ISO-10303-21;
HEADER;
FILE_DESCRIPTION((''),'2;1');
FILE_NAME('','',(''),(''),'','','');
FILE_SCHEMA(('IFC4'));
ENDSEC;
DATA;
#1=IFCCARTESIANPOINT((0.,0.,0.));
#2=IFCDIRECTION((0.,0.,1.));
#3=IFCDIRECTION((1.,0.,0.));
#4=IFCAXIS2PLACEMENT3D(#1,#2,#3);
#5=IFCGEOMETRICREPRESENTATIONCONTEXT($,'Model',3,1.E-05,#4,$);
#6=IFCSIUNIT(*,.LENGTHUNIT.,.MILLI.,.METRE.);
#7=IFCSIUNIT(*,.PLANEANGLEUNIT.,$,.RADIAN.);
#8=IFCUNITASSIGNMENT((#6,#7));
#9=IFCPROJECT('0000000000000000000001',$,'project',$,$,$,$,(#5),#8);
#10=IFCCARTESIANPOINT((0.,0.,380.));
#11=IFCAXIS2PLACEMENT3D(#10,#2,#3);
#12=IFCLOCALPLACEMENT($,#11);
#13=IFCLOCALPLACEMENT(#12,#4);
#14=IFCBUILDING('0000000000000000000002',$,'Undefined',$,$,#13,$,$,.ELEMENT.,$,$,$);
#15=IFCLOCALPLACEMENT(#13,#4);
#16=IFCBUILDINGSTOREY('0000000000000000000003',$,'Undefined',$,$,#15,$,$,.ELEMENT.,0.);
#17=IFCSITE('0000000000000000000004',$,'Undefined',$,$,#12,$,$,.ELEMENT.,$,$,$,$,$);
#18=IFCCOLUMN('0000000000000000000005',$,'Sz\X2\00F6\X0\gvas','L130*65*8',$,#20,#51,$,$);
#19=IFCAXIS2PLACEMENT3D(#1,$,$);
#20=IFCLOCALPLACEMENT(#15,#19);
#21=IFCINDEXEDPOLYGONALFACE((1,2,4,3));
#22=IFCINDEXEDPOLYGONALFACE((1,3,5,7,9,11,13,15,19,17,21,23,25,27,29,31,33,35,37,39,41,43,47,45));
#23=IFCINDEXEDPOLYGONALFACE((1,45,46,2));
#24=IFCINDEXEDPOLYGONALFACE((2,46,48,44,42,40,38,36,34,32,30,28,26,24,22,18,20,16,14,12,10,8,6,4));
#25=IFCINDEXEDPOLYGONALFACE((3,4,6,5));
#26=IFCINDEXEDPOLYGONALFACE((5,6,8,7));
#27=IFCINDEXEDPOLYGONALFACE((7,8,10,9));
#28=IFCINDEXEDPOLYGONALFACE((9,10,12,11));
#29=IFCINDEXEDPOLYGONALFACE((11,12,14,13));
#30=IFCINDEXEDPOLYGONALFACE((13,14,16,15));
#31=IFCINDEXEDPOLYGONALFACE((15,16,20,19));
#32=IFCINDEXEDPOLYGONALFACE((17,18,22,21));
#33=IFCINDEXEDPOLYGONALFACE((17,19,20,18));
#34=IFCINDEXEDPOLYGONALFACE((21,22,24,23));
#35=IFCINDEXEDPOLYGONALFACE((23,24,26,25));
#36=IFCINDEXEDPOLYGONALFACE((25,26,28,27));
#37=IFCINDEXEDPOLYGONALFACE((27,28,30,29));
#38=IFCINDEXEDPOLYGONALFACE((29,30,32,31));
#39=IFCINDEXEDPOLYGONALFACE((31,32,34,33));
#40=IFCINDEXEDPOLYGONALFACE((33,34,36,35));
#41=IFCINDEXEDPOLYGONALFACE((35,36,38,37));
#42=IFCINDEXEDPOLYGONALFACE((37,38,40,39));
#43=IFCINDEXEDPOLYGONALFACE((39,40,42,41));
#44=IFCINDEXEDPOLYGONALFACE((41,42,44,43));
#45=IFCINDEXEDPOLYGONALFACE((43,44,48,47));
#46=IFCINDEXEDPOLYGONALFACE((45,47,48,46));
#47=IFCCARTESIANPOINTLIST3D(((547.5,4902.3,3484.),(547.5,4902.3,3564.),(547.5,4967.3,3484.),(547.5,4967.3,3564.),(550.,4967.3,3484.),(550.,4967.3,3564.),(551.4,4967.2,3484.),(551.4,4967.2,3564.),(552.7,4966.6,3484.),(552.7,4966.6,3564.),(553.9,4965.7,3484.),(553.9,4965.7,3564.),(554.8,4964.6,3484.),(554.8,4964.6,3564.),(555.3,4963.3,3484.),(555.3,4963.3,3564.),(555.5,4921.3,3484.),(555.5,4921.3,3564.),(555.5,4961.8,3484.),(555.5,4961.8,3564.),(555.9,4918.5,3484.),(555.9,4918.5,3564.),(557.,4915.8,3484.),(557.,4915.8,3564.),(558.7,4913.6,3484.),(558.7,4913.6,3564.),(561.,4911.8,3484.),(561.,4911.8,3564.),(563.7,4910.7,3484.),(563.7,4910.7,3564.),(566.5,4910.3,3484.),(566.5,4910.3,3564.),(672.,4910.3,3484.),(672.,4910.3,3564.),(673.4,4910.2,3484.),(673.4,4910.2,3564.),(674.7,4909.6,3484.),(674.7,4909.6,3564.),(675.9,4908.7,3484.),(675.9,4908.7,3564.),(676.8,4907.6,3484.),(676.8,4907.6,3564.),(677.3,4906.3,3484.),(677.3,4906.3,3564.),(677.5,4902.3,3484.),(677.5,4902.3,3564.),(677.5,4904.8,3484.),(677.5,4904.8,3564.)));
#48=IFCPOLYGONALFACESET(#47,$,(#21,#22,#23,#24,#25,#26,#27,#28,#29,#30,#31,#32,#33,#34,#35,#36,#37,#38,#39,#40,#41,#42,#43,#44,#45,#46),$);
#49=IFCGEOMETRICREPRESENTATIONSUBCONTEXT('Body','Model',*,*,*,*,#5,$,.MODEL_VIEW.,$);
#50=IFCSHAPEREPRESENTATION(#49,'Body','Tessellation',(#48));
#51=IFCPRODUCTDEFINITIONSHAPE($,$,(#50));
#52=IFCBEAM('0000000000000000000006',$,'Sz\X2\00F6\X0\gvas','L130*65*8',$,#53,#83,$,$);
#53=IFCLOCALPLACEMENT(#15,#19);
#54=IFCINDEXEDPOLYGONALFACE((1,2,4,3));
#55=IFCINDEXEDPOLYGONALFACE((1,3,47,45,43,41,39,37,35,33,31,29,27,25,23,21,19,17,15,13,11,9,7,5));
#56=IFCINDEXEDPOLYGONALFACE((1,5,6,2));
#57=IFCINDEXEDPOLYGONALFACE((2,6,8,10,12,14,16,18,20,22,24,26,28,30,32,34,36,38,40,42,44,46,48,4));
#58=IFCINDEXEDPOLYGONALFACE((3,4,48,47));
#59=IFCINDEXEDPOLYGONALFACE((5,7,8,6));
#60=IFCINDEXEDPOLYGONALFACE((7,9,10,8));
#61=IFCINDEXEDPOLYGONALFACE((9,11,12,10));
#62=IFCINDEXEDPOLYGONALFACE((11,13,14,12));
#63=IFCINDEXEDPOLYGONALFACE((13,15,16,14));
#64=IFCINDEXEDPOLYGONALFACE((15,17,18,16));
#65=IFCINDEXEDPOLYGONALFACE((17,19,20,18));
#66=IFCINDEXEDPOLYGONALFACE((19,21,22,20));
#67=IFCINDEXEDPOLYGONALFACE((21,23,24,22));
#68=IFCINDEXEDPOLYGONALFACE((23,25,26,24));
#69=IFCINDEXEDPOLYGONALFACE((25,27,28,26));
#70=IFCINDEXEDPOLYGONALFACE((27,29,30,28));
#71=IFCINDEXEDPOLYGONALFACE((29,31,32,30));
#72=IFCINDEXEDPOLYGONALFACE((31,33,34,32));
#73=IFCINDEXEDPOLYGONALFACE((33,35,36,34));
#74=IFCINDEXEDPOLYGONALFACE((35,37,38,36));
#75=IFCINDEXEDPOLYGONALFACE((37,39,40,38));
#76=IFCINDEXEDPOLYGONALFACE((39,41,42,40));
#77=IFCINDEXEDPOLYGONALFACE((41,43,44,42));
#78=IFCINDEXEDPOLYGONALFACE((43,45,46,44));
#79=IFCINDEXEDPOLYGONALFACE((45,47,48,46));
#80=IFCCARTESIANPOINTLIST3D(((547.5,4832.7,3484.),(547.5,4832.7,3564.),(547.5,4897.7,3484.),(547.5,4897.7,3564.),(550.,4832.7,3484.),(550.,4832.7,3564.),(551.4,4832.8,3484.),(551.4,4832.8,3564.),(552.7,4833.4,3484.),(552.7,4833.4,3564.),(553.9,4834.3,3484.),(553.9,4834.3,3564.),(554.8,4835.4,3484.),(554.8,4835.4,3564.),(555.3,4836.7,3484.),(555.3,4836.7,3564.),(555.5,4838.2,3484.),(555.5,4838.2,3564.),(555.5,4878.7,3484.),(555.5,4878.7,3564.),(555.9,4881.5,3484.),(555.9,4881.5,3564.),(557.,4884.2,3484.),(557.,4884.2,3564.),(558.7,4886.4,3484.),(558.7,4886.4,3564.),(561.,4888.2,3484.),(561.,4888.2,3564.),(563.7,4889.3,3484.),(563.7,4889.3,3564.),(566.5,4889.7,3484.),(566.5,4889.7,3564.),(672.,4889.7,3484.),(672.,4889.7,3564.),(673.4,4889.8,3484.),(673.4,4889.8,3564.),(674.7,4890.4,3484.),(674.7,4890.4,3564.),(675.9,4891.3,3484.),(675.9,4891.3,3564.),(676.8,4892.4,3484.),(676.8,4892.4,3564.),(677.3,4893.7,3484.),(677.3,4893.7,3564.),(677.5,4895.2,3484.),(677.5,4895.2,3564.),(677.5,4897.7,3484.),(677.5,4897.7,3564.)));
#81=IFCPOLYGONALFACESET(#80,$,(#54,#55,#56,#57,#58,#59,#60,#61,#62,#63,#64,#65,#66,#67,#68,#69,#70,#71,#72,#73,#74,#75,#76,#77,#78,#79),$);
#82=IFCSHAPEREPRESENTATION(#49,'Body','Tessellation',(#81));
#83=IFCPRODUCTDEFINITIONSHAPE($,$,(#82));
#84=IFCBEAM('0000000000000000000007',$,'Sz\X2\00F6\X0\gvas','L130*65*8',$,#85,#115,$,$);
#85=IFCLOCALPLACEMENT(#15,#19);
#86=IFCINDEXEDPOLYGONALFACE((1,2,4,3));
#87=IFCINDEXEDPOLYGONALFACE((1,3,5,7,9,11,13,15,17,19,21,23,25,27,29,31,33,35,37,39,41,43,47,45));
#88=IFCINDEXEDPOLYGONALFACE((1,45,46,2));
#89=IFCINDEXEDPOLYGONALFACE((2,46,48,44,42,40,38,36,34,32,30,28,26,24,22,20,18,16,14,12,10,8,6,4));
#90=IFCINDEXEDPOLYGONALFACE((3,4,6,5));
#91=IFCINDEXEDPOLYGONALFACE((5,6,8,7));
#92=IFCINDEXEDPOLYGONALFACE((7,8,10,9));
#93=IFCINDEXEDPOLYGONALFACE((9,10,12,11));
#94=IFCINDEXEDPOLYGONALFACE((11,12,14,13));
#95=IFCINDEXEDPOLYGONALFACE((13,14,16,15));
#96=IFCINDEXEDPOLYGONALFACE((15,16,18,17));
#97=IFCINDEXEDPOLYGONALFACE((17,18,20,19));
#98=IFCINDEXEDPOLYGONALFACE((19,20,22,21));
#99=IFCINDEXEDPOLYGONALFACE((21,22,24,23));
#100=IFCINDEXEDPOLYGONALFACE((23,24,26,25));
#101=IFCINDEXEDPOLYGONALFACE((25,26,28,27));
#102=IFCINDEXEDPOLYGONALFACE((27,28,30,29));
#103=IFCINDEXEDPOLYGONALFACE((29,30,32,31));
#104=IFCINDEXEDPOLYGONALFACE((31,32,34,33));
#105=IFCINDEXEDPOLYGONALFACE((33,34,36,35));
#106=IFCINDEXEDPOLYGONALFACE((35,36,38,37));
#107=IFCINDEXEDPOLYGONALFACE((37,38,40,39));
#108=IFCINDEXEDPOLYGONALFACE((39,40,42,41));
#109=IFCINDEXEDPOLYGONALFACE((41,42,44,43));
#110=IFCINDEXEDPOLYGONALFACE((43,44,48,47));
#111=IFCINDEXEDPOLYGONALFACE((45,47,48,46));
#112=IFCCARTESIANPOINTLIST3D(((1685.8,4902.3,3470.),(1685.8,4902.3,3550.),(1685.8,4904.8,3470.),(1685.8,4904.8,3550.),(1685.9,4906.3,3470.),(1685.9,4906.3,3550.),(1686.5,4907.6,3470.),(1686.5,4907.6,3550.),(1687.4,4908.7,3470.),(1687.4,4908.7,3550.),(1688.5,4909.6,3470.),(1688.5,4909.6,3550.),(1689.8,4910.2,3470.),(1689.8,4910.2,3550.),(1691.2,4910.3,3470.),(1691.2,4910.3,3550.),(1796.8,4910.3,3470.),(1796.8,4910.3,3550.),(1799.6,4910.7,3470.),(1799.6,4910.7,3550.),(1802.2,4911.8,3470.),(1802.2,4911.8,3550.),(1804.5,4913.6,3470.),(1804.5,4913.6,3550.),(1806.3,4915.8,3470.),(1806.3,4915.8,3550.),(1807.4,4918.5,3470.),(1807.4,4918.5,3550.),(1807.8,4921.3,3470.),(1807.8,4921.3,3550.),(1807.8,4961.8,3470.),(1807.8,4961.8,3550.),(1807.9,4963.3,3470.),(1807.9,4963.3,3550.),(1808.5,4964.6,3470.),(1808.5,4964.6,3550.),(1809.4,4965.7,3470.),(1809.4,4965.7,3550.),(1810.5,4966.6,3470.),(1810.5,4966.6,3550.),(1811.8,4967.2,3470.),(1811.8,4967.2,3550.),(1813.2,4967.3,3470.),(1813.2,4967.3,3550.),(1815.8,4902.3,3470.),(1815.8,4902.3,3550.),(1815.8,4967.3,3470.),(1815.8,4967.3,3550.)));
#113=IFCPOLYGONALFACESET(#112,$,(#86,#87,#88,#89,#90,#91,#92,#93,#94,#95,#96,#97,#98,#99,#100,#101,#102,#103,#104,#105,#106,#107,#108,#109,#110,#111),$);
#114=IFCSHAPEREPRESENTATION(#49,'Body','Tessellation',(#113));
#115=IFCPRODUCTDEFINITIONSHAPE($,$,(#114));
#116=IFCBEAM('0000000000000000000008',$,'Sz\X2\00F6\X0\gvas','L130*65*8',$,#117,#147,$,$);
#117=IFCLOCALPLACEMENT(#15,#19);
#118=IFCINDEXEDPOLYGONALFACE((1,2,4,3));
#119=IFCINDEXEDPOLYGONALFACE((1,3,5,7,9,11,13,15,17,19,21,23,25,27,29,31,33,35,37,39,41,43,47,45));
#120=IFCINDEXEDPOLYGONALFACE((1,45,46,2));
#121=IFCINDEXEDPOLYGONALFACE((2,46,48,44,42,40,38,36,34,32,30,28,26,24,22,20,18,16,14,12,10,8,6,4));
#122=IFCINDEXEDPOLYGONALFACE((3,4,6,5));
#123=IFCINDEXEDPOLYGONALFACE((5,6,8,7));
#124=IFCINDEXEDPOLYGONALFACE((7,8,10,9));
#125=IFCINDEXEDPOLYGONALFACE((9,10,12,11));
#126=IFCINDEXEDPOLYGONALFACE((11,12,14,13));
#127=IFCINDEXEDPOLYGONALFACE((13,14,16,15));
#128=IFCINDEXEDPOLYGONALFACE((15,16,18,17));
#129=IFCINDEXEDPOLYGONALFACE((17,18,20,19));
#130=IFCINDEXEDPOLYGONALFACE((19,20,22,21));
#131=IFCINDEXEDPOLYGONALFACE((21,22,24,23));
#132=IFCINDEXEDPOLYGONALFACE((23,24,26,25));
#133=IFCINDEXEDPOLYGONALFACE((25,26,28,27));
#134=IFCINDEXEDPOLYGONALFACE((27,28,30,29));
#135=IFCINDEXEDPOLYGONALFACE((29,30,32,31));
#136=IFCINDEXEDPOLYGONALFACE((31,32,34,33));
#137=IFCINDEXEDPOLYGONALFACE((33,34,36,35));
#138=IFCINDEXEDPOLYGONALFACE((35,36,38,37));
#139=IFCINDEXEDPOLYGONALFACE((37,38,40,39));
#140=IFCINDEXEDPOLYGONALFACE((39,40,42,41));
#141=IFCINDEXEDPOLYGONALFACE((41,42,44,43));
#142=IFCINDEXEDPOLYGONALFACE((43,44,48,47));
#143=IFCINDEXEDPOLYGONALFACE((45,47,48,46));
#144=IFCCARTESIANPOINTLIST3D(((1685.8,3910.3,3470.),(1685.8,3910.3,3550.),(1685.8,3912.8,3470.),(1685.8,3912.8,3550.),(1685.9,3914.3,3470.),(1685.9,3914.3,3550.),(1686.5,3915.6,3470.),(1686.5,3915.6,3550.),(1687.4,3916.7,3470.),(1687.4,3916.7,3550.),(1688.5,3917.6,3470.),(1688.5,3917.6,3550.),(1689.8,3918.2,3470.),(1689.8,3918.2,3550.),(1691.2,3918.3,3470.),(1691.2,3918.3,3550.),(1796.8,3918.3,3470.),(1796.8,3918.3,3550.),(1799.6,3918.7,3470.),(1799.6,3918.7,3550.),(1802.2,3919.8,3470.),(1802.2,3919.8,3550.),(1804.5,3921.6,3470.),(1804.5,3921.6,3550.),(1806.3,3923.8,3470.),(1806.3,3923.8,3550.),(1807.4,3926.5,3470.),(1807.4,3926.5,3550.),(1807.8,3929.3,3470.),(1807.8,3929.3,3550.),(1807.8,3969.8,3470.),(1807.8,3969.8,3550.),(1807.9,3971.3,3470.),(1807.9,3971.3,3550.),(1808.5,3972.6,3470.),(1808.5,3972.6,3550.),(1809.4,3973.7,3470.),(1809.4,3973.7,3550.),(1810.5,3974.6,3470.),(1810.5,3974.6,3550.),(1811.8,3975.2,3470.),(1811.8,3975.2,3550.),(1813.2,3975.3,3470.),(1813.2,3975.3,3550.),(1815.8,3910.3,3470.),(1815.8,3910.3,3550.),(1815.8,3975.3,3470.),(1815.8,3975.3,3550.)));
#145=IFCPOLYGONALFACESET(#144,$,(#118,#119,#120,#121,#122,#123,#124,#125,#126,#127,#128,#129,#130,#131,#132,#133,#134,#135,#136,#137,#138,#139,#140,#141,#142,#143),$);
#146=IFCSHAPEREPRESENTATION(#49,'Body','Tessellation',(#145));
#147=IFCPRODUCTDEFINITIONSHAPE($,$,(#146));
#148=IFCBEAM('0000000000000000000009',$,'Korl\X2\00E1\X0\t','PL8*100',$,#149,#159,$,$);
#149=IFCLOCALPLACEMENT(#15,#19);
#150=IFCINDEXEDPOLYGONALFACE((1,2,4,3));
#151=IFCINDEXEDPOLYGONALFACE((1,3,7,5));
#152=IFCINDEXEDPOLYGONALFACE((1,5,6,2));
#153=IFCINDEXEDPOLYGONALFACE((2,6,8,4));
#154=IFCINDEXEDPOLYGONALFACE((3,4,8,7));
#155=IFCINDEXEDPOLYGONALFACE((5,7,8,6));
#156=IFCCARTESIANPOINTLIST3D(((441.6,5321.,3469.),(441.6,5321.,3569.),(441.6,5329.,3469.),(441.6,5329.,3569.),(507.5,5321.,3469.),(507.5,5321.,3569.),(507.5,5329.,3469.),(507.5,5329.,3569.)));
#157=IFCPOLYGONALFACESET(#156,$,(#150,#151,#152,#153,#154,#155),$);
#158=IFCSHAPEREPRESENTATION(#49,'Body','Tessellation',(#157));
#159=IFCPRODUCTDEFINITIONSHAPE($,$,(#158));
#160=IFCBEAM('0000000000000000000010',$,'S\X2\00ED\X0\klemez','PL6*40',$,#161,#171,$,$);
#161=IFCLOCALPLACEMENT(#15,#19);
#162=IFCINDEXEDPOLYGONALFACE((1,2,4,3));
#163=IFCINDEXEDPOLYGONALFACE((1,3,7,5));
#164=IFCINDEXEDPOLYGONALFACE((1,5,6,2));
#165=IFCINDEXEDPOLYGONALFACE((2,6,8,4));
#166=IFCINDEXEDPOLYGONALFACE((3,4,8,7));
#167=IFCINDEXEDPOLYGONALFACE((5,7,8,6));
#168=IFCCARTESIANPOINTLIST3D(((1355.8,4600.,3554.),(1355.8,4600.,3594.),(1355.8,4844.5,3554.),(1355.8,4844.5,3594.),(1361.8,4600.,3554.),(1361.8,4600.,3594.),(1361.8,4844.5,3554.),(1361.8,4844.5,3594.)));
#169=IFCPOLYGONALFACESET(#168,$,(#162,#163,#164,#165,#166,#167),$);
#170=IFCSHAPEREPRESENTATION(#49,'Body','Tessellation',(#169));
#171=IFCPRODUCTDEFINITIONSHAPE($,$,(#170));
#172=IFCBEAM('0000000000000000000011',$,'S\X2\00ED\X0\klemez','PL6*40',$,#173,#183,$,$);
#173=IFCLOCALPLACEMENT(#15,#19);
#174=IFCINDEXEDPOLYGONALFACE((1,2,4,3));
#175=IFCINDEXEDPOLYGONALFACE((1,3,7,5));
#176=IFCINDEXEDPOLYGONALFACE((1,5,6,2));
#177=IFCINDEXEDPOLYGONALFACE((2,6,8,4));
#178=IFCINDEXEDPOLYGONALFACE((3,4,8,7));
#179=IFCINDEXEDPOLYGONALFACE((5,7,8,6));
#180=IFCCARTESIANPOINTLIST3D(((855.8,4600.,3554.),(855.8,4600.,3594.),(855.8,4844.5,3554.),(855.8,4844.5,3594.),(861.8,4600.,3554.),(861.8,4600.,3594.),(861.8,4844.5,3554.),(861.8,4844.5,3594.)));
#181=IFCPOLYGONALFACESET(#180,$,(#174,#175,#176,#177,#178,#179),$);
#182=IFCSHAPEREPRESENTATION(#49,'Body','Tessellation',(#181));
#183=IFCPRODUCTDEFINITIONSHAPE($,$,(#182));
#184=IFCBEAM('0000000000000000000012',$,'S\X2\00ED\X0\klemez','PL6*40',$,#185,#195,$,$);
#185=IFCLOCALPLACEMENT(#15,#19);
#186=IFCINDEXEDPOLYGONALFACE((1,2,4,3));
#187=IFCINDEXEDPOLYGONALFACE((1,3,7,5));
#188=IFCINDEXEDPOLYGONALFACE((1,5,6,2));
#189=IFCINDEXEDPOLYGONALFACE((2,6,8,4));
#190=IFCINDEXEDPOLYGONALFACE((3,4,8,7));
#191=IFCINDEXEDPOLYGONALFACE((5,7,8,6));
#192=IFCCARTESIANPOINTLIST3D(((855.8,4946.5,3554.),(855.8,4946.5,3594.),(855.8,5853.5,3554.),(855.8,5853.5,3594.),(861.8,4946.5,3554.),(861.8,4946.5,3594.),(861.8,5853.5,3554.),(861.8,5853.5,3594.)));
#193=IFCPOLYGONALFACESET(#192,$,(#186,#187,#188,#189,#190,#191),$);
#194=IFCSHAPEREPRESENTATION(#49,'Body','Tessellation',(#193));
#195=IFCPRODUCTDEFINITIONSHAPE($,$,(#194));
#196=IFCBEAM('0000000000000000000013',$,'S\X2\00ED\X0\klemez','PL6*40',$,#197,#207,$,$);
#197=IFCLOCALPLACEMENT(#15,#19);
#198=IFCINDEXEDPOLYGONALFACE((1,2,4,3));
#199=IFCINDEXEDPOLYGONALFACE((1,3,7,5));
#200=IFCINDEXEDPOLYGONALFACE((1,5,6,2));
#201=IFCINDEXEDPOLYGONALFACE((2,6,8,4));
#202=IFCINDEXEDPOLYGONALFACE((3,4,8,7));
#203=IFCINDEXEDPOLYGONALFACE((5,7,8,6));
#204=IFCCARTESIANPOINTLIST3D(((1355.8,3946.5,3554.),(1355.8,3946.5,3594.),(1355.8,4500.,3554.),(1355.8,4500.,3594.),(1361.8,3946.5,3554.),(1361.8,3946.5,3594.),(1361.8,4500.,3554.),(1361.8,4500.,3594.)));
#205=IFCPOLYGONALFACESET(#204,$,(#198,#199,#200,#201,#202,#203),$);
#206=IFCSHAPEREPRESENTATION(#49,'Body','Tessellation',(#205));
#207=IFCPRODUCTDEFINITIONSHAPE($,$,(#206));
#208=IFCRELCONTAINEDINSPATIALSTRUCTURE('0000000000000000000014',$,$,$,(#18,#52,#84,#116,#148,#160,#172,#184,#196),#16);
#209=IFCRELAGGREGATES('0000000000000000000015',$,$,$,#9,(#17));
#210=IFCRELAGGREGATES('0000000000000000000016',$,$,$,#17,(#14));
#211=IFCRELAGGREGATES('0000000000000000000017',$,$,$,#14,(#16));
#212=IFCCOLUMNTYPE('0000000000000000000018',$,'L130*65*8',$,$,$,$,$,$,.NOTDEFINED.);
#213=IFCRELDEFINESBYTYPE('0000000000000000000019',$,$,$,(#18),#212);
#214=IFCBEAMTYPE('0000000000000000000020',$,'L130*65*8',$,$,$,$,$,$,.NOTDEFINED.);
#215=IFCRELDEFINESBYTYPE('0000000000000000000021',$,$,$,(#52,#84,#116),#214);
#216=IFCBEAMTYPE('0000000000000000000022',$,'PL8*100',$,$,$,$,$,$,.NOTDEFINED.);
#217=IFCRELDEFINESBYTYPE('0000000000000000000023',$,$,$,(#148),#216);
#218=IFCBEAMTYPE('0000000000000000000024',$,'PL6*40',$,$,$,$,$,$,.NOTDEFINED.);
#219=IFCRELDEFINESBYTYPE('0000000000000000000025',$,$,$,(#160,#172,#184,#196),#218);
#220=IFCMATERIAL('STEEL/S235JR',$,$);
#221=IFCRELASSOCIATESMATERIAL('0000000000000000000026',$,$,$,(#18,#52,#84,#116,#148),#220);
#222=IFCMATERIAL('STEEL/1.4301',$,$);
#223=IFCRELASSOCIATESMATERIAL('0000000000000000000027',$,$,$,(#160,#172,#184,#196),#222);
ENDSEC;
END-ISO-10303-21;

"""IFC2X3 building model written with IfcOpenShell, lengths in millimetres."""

from ifc_helpers import new_model, si_unit, frame, origin_with_axes, origin_2d_with_axis, place, context, subcontext, project, spatial, rectangle, l_section, extrude, material, type_object, element, save


model = new_model("IFC2X3")

# Units and contexts
model_context = context("Model", 3, precision=1e-05, world=origin_with_axes())
body_context = subcontext(model_context, "Body", "Model", "MODEL_VIEW")
ifc_project = project(units=[si_unit("LENGTHUNIT", "METRE", prefix="MILLI"), si_unit("PLANEANGLEUNIT", "RADIAN")], contexts=[model_context])

# Site, building, storey
site_placement = place(None, frame((0.0, 0.0, 380.0), z_axis=(0.0, 0.0, 1.0), x_axis=(1.0, 0.0, 0.0)))
site = spatial("IfcSite", under=ifc_project, at=site_placement, Name="Undefined", CompositionType="ELEMENT")
building_placement = place(site_placement, origin_with_axes())
building = spatial("IfcBuilding", under=site, at=building_placement, Name="Undefined", CompositionType="ELEMENT")
storey_placement = place(building_placement, origin_with_axes())
storey = spatial("IfcBuildingStorey", under=building, at=storey_placement, Name="Undefined", CompositionType="ELEMENT", Elevation=0.0)

# Column
ifc_material_1 = material(Name="STEEL/S235JR")
column_type_1 = type_object("IfcColumnType", Name="L130*65*8", PredefinedType="NOTDEFINED")
column_1_placement = place(storey_placement, frame((612.5, 4934.8, 3484.0), z_axis=(0.0, 0.0, 1.0), x_axis=(1.0, 0.0, 0.0)))
element("IfcColumn", 1, at=column_1_placement, inside=storey, type_object=column_type_1, material=ifc_material_1, Name="Szögvas", Description="L130*65*8", context=body_context, shape_type="SweptSolid", body=[
    extrude(l_section(Depth=130.0, Width=65.0, Thickness=8.0, FilletRadius=11.0, EdgeRadius=5.5, at=origin_2d_with_axis()), frame((0.0, 0.0, 80.0), z_axis=(0.0, 0.0, -1.0), x_axis=(0.0, 1.0, 0.0)), (0.0, 0.0, 1.0), 80.0),
])

# Beams
beam_type_1 = type_object("IfcBeamType", Name="L130*65*8", PredefinedType="NOTDEFINED")
for number, where, z_axis, x_axis, name in (
    (2, (612.5, 4865.2, 3564.0), (1.0, 0.0, 0.0), (0.0, 0.0, -1.0), "Szögvas"),
    (3, (1750.8, 4934.8, 3550.0), (-1.0, 0.0, 0.0), (0.0, 0.0, -1.0), "Szögvas"),
    (4, (1750.8, 3942.8, 3550.0), (-1.0, 0.0, 0.0), (0.0, 0.0, -1.0), "Szögvas"),
):
    element("IfcBeam", number, at=place(storey_placement, frame(where, z_axis=z_axis, x_axis=x_axis)), inside=storey, type_object=beam_type_1, material=ifc_material_1, Name=name, Description="L130*65*8", context=body_context, shape_type="SweptSolid", body=[
        extrude(l_section(Depth=130.0, Width=65.0, Thickness=8.0, FilletRadius=11.0, EdgeRadius=5.5, at=origin_2d_with_axis()), frame((80.0, 0.0, 0.0), z_axis=(-1.0, 0.0, 0.0), x_axis=(0.0, -1.0, 0.0)), (0.0, 0.0, 1.0), 80.0),
    ])
beam_type_2 = type_object("IfcBeamType", Name="PL8*100", PredefinedType="NOTDEFINED")
beam_1_placement = place(storey_placement, frame((507.5, 5325.0, 3519.0), z_axis=(0.0, 0.0, 1.0), x_axis=(-1.0, 0.0, 0.0)))
element("IfcBeam", 5, at=beam_1_placement, inside=storey, type_object=beam_type_2, material=ifc_material_1, Name="Korlát", Description="PL8*100", context=body_context, shape_type="SweptSolid", body=[
    extrude(rectangle(XDim=8.0, YDim=100.0, at=origin_2d_with_axis()), frame((65.9, 0.0, 0.0), z_axis=(-1.0, 0.0, 0.0), x_axis=(0.0, -1.0, 0.0)), (0.0, 0.0, 1.0), 65.8),
])
ifc_material_2 = material(Name="STEEL/1.4301")
beam_type_3 = type_object("IfcBeamType", Name="PL6*40", PredefinedType="NOTDEFINED")
for number, where, z_axis, x_axis, name in (
    (6, (1358.8, 4844.5, 3574.0), (0.0, 0.0, 1.0), (0.0, -1.0, 0.0), "Síklemez"),
    (7, (858.8, 4844.5, 3574.0), (0.0, 0.0, 1.0), (0.0, -1.0, 0.0), "Síklemez"),
):
    element("IfcBeam", number, at=place(storey_placement, frame(where, z_axis=z_axis, x_axis=x_axis)), inside=storey, type_object=beam_type_3, material=ifc_material_2, Name=name, Description="PL6*40", context=body_context, shape_type="SweptSolid", body=[
        extrude(rectangle(XDim=6.0, YDim=40.0, at=origin_2d_with_axis()), frame((244.5, 0.0, 0.0), z_axis=(-1.0, 0.0, 0.0), x_axis=(0.0, -1.0, 0.0)), (0.0, 0.0, 1.0), 244.5),
    ])
beam_2_placement = place(storey_placement, frame((858.8, 5853.5, 3574.0), z_axis=(0.0, 0.0, 1.0), x_axis=(0.0, -1.0, 0.0)))
element("IfcBeam", 8, at=beam_2_placement, inside=storey, type_object=beam_type_3, material=ifc_material_2, Name="Síklemez", Description="PL6*40", context=body_context, shape_type="SweptSolid", body=[
    extrude(rectangle(XDim=6.0, YDim=40.0, at=origin_2d_with_axis()), frame((907.0, 0.0, 0.0), z_axis=(-1.0, 0.0, 0.0), x_axis=(0.0, -1.0, 0.0)), (0.0, 0.0, 1.0), 907.0),
])
for number, where, z_axis, x_axis, name in (
    (9, (1358.8, 4500.0, 3574.0), (0.0, 0.0, 1.0), (0.0, -1.0, 0.0), "Síklemez"),
):
    element("IfcBeam", number, at=place(storey_placement, frame(where, z_axis=z_axis, x_axis=x_axis)), inside=storey, type_object=beam_type_3, material=ifc_material_2, Name=name, Description="PL6*40", context=body_context, shape_type="SweptSolid", body=[
        extrude(rectangle(XDim=6.0, YDim=40.0, at=origin_2d_with_axis()), frame((553.5, 0.0, 0.0), z_axis=(-1.0, 0.0, 0.0), x_axis=(0.0, -1.0, 0.0)), (0.0, 0.0, 1.0), 553.5),
    ])

save(model, "model.ifc")
